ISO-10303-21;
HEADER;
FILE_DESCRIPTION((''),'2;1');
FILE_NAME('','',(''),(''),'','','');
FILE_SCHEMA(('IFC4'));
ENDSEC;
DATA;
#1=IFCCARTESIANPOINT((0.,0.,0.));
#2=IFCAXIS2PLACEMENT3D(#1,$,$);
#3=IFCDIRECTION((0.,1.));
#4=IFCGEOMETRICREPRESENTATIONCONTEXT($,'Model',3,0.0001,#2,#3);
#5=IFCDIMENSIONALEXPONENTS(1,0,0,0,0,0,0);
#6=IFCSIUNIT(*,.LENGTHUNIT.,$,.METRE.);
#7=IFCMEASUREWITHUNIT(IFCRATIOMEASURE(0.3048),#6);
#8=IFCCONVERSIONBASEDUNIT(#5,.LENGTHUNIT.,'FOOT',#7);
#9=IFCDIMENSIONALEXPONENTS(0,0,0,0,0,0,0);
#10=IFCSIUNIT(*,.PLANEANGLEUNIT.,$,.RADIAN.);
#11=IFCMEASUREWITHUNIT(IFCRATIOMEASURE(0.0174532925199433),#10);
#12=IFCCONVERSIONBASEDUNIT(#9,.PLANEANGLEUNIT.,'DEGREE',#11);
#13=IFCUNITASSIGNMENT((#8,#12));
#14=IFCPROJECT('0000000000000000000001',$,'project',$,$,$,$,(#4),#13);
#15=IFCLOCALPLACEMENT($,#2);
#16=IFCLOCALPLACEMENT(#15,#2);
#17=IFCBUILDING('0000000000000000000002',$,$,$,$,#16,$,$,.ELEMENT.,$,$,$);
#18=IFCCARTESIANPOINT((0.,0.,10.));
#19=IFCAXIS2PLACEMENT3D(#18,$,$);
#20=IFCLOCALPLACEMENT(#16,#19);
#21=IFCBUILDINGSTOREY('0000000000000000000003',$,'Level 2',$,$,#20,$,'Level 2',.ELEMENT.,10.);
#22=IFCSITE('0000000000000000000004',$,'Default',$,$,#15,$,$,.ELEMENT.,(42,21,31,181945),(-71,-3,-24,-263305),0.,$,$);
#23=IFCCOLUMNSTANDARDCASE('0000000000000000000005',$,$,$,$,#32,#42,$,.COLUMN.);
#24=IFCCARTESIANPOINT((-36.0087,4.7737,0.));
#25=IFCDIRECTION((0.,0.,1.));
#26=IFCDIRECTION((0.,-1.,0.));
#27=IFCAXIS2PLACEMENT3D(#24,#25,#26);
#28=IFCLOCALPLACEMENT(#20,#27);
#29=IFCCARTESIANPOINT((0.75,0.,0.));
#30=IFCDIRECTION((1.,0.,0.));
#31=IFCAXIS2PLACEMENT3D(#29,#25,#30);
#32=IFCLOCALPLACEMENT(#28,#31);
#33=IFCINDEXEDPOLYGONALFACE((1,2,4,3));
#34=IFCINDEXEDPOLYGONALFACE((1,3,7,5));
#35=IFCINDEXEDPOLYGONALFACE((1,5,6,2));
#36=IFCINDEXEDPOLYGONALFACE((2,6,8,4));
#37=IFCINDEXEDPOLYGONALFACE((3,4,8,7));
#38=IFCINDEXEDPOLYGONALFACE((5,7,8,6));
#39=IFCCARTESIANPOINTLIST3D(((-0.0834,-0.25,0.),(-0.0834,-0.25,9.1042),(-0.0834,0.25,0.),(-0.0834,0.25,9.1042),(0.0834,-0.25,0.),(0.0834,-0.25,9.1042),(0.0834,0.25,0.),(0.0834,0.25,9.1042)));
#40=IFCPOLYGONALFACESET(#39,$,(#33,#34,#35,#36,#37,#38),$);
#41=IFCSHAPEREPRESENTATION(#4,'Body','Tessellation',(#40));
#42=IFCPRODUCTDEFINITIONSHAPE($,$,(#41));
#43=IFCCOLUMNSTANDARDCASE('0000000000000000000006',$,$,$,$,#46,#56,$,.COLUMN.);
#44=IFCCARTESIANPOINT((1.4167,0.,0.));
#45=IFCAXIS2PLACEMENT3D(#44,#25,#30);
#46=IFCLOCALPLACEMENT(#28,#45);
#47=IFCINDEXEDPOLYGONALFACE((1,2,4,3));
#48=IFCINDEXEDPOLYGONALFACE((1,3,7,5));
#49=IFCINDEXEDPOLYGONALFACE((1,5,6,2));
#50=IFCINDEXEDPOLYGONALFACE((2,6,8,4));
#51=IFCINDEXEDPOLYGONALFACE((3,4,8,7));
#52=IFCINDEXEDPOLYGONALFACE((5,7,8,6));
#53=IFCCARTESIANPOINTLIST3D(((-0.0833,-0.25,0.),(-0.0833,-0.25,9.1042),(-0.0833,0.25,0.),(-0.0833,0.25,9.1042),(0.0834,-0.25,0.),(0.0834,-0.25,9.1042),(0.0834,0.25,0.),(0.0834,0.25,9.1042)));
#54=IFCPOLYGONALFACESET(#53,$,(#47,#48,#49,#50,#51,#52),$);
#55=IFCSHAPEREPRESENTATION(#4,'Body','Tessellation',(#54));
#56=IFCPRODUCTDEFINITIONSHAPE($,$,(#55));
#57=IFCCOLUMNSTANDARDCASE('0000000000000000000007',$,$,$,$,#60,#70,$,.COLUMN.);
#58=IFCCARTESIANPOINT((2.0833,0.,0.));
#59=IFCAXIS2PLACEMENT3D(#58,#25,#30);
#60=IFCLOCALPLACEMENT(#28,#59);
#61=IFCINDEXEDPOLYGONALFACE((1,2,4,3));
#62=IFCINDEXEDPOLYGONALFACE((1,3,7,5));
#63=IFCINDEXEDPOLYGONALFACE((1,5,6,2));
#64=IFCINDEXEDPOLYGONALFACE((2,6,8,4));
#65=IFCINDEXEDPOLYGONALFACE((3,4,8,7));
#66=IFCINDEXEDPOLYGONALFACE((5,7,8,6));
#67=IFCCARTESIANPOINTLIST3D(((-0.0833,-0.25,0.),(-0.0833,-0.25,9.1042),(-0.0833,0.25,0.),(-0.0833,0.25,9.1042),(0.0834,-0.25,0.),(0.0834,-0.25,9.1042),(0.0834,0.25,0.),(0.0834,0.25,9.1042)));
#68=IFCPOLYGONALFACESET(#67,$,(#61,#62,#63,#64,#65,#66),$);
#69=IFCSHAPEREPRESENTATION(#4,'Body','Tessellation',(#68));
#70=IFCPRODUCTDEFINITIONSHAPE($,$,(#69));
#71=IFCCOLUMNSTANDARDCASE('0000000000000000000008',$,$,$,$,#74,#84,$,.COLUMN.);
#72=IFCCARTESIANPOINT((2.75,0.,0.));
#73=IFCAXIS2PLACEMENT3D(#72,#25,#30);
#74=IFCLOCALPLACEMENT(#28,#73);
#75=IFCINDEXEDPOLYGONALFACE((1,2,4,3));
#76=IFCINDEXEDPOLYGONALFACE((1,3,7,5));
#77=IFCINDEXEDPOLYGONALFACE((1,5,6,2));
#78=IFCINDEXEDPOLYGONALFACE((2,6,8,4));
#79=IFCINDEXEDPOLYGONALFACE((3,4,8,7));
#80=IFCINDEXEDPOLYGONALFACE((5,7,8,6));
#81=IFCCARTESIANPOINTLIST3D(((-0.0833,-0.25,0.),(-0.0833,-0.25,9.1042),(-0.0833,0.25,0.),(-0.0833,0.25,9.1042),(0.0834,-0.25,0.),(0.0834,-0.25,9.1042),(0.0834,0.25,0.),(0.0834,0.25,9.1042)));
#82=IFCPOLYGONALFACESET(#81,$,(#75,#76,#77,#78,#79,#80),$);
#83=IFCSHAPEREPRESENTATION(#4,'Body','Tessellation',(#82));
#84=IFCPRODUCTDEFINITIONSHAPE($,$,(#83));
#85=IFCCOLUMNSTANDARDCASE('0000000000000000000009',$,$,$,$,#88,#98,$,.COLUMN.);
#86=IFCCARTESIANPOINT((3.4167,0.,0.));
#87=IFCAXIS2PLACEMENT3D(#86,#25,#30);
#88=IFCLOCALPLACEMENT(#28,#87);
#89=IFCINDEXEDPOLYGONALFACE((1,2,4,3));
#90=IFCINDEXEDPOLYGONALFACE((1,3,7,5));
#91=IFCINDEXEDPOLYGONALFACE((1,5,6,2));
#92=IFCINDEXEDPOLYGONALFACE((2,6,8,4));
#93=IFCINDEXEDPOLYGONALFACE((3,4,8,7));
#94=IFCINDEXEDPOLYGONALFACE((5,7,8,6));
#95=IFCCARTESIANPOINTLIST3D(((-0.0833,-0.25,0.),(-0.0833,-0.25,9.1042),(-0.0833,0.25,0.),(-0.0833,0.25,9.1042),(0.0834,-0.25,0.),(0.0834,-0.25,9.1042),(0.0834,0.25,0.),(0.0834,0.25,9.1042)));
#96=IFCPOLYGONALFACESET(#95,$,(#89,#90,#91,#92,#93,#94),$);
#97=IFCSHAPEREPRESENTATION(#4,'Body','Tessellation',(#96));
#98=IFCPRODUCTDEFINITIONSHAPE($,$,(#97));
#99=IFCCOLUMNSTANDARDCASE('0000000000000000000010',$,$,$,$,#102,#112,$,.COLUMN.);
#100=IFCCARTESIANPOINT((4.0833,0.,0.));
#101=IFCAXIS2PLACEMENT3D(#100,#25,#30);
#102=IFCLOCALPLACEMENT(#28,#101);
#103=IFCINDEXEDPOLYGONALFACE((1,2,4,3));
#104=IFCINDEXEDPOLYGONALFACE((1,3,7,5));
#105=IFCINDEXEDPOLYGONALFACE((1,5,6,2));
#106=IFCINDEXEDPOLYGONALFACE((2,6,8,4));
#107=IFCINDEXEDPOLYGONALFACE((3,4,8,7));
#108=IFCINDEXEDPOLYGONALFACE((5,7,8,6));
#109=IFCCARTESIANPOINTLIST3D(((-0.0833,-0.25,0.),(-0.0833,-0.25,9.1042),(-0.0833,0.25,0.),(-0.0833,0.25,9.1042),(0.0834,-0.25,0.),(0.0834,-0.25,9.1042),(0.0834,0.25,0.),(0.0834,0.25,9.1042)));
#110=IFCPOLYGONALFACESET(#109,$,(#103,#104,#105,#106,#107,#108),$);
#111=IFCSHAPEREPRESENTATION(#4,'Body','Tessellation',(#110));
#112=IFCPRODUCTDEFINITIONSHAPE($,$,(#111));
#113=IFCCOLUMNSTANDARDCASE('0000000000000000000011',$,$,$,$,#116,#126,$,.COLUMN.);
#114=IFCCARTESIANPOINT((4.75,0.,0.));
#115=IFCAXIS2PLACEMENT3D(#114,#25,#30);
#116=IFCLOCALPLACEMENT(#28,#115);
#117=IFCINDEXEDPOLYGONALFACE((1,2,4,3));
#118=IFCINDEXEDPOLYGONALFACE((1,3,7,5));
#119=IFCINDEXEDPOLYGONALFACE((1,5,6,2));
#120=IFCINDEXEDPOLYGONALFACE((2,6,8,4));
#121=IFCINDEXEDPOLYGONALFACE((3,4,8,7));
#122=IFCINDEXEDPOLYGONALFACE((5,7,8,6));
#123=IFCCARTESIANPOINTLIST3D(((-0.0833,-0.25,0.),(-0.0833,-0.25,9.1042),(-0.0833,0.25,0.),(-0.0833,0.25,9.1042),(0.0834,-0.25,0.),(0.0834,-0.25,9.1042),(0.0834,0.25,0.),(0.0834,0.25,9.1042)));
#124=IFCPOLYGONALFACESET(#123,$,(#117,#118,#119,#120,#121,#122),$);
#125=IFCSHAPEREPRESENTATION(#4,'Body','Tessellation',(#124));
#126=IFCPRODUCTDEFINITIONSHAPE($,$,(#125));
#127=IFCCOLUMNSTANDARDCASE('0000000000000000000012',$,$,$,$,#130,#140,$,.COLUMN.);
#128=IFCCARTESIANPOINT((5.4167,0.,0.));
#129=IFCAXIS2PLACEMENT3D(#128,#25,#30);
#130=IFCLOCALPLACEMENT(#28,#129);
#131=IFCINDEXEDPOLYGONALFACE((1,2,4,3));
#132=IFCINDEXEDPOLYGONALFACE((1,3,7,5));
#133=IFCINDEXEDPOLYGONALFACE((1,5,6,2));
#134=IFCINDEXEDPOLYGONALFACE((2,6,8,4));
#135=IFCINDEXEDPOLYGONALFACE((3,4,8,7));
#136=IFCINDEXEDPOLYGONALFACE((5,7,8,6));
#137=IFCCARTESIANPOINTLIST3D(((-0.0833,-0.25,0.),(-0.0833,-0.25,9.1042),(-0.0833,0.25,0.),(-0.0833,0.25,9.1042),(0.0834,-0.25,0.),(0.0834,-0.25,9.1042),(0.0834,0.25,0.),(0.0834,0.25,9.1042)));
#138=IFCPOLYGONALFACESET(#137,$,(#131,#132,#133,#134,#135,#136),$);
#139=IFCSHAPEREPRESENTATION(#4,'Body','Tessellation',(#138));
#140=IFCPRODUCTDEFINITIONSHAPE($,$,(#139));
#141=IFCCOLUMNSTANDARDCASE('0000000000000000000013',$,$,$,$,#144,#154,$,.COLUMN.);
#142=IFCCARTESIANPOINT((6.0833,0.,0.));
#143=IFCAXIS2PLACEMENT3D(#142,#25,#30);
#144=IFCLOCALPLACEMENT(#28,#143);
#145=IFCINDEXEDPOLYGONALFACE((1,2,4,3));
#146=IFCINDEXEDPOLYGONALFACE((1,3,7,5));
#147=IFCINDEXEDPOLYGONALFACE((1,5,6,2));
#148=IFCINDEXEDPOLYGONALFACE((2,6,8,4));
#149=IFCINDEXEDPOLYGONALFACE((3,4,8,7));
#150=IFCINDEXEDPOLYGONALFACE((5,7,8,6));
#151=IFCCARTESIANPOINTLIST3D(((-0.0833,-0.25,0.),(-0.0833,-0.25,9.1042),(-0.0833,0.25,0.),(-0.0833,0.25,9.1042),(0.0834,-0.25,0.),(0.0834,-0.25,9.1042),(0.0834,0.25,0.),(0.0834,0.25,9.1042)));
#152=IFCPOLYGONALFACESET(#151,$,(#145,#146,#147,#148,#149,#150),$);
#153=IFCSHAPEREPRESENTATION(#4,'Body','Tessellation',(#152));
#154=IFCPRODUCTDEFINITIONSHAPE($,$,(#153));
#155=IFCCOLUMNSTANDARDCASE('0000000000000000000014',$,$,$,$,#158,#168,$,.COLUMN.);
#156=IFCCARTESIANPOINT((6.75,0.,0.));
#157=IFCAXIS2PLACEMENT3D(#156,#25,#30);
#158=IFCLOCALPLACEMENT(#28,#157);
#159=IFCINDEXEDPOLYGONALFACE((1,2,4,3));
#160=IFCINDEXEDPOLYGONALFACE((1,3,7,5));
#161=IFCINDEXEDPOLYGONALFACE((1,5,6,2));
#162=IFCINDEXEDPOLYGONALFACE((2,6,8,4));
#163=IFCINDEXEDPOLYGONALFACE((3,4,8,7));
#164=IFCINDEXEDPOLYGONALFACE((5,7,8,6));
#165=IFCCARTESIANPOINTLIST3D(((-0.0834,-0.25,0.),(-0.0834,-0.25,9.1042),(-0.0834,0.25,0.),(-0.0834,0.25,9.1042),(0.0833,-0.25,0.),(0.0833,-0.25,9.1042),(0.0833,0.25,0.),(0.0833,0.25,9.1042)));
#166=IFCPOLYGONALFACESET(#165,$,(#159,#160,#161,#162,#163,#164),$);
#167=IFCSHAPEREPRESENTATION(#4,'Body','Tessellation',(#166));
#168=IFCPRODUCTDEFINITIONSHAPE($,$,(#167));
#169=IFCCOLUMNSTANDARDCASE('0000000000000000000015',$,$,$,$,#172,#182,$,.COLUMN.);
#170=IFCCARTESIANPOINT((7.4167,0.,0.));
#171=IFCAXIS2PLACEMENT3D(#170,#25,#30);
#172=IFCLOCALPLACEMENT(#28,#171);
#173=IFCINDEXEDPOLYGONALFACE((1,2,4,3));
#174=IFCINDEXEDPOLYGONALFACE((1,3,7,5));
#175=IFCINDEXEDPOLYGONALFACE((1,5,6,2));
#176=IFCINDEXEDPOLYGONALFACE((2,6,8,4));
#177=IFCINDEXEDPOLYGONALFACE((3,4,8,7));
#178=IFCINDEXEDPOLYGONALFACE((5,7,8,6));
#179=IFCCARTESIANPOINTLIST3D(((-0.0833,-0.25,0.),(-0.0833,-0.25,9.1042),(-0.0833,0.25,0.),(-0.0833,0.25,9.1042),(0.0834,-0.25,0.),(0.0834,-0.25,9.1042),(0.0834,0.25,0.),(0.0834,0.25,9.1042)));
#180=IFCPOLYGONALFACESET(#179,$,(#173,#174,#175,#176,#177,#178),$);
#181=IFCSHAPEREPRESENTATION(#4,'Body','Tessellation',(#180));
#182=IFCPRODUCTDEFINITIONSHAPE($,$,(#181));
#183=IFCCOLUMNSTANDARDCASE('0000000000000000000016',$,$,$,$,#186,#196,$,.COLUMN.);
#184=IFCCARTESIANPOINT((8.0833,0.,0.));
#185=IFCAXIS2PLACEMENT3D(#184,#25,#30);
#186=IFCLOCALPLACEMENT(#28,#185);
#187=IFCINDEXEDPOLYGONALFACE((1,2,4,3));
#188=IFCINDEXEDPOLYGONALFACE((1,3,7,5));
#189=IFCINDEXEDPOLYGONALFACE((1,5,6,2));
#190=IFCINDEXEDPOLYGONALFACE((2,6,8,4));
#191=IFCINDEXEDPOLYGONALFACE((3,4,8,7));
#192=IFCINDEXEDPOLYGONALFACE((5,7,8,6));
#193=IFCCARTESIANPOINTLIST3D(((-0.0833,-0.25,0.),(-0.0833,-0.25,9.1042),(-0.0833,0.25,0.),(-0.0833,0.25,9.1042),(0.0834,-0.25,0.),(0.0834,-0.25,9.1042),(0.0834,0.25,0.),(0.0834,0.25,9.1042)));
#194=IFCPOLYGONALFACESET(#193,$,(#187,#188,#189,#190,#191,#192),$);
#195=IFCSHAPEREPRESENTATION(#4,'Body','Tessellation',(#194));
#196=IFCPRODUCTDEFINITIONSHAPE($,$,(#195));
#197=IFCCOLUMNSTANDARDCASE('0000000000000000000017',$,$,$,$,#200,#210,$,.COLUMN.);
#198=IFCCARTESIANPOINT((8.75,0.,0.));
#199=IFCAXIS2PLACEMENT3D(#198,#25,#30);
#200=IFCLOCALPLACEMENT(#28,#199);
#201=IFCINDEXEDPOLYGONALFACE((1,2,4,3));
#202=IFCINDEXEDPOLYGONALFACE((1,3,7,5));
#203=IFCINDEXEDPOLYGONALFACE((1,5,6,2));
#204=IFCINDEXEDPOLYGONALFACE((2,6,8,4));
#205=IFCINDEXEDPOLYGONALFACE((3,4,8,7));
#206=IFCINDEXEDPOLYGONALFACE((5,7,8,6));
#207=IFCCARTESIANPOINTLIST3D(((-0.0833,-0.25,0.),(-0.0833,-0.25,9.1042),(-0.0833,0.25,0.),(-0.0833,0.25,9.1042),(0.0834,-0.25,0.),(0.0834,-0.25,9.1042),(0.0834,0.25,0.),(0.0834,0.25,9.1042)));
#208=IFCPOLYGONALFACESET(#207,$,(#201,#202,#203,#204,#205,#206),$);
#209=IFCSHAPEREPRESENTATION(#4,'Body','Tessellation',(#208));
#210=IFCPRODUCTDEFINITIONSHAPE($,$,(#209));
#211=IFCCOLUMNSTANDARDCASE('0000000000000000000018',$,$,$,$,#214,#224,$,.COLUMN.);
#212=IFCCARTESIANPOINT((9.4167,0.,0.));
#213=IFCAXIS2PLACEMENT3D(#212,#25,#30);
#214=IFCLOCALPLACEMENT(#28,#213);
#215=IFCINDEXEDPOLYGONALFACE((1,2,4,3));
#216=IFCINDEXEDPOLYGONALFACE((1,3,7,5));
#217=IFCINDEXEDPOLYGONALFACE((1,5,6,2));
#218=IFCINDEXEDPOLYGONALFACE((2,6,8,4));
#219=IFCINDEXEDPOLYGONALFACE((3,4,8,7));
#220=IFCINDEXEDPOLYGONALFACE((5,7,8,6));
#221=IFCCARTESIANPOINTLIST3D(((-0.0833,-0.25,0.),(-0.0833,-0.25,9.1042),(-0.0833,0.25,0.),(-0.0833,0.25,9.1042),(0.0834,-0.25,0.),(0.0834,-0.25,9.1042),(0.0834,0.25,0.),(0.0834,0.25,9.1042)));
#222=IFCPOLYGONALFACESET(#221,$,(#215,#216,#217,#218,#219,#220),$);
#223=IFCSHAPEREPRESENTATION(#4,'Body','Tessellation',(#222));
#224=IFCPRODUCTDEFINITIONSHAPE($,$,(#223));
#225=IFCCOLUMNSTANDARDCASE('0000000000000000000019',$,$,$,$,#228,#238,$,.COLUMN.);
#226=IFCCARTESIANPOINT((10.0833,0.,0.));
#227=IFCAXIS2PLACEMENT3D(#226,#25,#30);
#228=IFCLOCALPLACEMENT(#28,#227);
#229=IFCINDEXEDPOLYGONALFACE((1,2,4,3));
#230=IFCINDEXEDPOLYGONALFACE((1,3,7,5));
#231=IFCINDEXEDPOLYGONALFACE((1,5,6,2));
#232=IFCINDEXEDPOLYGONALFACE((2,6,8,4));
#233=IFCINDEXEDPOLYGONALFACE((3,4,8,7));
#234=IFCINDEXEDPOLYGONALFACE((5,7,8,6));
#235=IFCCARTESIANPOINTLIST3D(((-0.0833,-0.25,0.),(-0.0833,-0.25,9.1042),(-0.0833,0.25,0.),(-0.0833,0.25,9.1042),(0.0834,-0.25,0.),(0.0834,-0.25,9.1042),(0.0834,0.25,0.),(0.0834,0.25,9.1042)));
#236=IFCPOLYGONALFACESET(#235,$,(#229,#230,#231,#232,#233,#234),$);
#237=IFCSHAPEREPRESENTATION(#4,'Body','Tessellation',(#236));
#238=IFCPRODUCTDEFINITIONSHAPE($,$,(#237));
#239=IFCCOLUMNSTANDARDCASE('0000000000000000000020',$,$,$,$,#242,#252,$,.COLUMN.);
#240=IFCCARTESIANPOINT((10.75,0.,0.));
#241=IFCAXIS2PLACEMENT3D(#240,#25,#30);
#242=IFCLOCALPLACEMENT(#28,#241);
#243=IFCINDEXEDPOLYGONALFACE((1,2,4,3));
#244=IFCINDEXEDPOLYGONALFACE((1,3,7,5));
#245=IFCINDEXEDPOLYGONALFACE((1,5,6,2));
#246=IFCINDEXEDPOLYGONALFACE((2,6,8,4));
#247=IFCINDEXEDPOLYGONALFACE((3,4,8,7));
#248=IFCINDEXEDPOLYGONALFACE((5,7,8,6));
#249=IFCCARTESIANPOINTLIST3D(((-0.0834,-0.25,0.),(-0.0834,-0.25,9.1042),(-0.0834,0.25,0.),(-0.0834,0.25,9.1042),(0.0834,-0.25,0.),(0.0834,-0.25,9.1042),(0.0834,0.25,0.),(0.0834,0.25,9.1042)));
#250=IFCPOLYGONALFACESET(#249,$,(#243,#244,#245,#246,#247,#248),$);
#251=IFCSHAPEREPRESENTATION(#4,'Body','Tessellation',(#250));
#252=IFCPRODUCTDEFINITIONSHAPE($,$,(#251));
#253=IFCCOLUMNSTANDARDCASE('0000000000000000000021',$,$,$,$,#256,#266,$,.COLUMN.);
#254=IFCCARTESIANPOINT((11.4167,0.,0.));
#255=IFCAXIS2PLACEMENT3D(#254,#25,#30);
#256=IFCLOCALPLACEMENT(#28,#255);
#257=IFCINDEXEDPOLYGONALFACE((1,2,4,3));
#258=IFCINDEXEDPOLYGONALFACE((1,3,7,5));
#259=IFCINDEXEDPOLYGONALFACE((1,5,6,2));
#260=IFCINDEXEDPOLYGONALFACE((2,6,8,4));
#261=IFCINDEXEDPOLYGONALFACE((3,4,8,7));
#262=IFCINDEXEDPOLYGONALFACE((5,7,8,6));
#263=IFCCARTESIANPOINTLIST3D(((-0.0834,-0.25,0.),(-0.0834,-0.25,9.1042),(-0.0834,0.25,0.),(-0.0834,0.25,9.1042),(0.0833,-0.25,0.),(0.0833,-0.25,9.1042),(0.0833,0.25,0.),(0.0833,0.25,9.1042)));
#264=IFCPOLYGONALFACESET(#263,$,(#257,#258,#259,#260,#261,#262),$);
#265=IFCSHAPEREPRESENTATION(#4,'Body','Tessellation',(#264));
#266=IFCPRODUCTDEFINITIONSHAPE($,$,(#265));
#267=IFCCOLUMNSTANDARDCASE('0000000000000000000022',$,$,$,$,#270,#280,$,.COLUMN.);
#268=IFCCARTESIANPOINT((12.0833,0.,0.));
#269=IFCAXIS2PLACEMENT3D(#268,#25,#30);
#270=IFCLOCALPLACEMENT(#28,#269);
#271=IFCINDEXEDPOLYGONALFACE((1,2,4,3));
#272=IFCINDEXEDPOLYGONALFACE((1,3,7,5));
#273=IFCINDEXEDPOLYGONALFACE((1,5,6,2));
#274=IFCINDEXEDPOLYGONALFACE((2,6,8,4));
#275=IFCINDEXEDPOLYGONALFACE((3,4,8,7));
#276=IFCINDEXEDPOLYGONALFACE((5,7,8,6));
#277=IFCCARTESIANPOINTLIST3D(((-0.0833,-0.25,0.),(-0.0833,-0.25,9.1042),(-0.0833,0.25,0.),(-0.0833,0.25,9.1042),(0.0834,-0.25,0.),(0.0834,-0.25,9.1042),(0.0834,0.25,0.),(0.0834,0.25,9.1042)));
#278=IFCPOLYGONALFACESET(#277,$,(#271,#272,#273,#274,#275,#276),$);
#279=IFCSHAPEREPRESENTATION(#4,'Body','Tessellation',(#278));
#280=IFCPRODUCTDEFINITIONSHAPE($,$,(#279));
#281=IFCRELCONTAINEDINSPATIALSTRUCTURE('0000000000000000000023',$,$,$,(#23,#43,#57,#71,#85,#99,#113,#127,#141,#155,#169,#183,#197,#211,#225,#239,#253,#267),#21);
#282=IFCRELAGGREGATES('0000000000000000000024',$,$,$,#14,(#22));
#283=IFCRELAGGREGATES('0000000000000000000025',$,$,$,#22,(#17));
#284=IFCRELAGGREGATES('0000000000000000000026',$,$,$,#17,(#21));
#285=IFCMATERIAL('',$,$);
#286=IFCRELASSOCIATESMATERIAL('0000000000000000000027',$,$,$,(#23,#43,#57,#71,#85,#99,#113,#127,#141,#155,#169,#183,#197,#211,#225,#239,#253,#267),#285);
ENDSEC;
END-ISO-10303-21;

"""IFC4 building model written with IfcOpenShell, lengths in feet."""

from ifc_helpers import new_model, entity, si_unit, converted_unit, direction, frame, origin, place, context, project, spatial, rectangle, extrude, material, element, save


model = new_model("IFC4")

# Units and contexts
model_context = context("Model", 3, precision=0.0001, world=origin(), true_north=direction((0.0, 1.0)))
ifc_project = project(units=[converted_unit("LENGTHUNIT", "FOOT", entity("IfcRatioMeasure", 0.3048), si_unit("LENGTHUNIT", "METRE"), dimensions=[1, 0, 0, 0, 0, 0, 0]), converted_unit("PLANEANGLEUNIT", "DEGREE", entity("IfcRatioMeasure", 0.0174532925199433), si_unit("PLANEANGLEUNIT", "RADIAN"), dimensions=[0, 0, 0, 0, 0, 0, 0])], contexts=[model_context])

# Site, building, storey
site_placement = place(None, origin())
site = spatial("IfcSite", under=ifc_project, at=site_placement, Name="Default", CompositionType="ELEMENT", RefLatitude=(42, 21, 31, 181945), RefLongitude=(-71, -3, -24, -263305), RefElevation=0.0)
building_placement = place(site_placement, origin())
building = spatial("IfcBuilding", under=site, at=building_placement, CompositionType="ELEMENT")
storey_placement = place(building_placement, frame((0.0, 0.0, 10.0)))
storey = spatial("IfcBuildingStorey", under=building, at=storey_placement, Name="Level 2", LongName="Level 2", CompositionType="ELEMENT", Elevation=10.0)

# Columns
ifc_material_1 = material(Name="")
placement = place(storey_placement, frame((-36.0087, 4.7737, 0.0), z_axis=(0.0, 0.0, 1.0), x_axis=(0.0, -1.0, 0.0)))
for number, where, z_axis, x_axis in (
    (1, (0.75, 0.0, 0.0), (0.0, 0.0, 1.0), (1.0, 0.0, 0.0)),
    (2, (1.4167, 0.0, 0.0), (0.0, 0.0, 1.0), (1.0, 0.0, 0.0)),
    (3, (2.0833, 0.0, 0.0), (0.0, 0.0, 1.0), (1.0, 0.0, 0.0)),
    (4, (2.75, 0.0, 0.0), (0.0, 0.0, 1.0), (1.0, 0.0, 0.0)),
    (5, (3.4167, 0.0, 0.0), (0.0, 0.0, 1.0), (1.0, 0.0, 0.0)),
    (6, (4.0833, 0.0, 0.0), (0.0, 0.0, 1.0), (1.0, 0.0, 0.0)),
    (7, (4.75, 0.0, 0.0), (0.0, 0.0, 1.0), (1.0, 0.0, 0.0)),
    (8, (5.4167, 0.0, 0.0), (0.0, 0.0, 1.0), (1.0, 0.0, 0.0)),
    (9, (6.0833, 0.0, 0.0), (0.0, 0.0, 1.0), (1.0, 0.0, 0.0)),
    (10, (6.75, 0.0, 0.0), (0.0, 0.0, 1.0), (1.0, 0.0, 0.0)),
    (11, (7.4167, 0.0, 0.0), (0.0, 0.0, 1.0), (1.0, 0.0, 0.0)),
    (12, (8.0833, 0.0, 0.0), (0.0, 0.0, 1.0), (1.0, 0.0, 0.0)),
    (13, (8.75, 0.0, 0.0), (0.0, 0.0, 1.0), (1.0, 0.0, 0.0)),
    (14, (9.4167, 0.0, 0.0), (0.0, 0.0, 1.0), (1.0, 0.0, 0.0)),
    (15, (10.0833, 0.0, 0.0), (0.0, 0.0, 1.0), (1.0, 0.0, 0.0)),
    (16, (10.75, 0.0, 0.0), (0.0, 0.0, 1.0), (1.0, 0.0, 0.0)),
    (17, (11.4167, 0.0, 0.0), (0.0, 0.0, 1.0), (1.0, 0.0, 0.0)),
    (18, (12.0833, 0.0, 0.0), (0.0, 0.0, 1.0), (1.0, 0.0, 0.0)),
):
    element("IfcColumnStandardCase", number, at=place(placement, frame(where, z_axis=z_axis, x_axis=x_axis)), inside=storey, material=ifc_material_1, PredefinedType="COLUMN", context=model_context, shape_type="SweptSolid", body=[
        extrude(rectangle(XDim=0.1667, YDim=0.5), origin(), (0.0, 0.0, 1.0), 9.1042),
    ])

save(model, "model.ifc")
